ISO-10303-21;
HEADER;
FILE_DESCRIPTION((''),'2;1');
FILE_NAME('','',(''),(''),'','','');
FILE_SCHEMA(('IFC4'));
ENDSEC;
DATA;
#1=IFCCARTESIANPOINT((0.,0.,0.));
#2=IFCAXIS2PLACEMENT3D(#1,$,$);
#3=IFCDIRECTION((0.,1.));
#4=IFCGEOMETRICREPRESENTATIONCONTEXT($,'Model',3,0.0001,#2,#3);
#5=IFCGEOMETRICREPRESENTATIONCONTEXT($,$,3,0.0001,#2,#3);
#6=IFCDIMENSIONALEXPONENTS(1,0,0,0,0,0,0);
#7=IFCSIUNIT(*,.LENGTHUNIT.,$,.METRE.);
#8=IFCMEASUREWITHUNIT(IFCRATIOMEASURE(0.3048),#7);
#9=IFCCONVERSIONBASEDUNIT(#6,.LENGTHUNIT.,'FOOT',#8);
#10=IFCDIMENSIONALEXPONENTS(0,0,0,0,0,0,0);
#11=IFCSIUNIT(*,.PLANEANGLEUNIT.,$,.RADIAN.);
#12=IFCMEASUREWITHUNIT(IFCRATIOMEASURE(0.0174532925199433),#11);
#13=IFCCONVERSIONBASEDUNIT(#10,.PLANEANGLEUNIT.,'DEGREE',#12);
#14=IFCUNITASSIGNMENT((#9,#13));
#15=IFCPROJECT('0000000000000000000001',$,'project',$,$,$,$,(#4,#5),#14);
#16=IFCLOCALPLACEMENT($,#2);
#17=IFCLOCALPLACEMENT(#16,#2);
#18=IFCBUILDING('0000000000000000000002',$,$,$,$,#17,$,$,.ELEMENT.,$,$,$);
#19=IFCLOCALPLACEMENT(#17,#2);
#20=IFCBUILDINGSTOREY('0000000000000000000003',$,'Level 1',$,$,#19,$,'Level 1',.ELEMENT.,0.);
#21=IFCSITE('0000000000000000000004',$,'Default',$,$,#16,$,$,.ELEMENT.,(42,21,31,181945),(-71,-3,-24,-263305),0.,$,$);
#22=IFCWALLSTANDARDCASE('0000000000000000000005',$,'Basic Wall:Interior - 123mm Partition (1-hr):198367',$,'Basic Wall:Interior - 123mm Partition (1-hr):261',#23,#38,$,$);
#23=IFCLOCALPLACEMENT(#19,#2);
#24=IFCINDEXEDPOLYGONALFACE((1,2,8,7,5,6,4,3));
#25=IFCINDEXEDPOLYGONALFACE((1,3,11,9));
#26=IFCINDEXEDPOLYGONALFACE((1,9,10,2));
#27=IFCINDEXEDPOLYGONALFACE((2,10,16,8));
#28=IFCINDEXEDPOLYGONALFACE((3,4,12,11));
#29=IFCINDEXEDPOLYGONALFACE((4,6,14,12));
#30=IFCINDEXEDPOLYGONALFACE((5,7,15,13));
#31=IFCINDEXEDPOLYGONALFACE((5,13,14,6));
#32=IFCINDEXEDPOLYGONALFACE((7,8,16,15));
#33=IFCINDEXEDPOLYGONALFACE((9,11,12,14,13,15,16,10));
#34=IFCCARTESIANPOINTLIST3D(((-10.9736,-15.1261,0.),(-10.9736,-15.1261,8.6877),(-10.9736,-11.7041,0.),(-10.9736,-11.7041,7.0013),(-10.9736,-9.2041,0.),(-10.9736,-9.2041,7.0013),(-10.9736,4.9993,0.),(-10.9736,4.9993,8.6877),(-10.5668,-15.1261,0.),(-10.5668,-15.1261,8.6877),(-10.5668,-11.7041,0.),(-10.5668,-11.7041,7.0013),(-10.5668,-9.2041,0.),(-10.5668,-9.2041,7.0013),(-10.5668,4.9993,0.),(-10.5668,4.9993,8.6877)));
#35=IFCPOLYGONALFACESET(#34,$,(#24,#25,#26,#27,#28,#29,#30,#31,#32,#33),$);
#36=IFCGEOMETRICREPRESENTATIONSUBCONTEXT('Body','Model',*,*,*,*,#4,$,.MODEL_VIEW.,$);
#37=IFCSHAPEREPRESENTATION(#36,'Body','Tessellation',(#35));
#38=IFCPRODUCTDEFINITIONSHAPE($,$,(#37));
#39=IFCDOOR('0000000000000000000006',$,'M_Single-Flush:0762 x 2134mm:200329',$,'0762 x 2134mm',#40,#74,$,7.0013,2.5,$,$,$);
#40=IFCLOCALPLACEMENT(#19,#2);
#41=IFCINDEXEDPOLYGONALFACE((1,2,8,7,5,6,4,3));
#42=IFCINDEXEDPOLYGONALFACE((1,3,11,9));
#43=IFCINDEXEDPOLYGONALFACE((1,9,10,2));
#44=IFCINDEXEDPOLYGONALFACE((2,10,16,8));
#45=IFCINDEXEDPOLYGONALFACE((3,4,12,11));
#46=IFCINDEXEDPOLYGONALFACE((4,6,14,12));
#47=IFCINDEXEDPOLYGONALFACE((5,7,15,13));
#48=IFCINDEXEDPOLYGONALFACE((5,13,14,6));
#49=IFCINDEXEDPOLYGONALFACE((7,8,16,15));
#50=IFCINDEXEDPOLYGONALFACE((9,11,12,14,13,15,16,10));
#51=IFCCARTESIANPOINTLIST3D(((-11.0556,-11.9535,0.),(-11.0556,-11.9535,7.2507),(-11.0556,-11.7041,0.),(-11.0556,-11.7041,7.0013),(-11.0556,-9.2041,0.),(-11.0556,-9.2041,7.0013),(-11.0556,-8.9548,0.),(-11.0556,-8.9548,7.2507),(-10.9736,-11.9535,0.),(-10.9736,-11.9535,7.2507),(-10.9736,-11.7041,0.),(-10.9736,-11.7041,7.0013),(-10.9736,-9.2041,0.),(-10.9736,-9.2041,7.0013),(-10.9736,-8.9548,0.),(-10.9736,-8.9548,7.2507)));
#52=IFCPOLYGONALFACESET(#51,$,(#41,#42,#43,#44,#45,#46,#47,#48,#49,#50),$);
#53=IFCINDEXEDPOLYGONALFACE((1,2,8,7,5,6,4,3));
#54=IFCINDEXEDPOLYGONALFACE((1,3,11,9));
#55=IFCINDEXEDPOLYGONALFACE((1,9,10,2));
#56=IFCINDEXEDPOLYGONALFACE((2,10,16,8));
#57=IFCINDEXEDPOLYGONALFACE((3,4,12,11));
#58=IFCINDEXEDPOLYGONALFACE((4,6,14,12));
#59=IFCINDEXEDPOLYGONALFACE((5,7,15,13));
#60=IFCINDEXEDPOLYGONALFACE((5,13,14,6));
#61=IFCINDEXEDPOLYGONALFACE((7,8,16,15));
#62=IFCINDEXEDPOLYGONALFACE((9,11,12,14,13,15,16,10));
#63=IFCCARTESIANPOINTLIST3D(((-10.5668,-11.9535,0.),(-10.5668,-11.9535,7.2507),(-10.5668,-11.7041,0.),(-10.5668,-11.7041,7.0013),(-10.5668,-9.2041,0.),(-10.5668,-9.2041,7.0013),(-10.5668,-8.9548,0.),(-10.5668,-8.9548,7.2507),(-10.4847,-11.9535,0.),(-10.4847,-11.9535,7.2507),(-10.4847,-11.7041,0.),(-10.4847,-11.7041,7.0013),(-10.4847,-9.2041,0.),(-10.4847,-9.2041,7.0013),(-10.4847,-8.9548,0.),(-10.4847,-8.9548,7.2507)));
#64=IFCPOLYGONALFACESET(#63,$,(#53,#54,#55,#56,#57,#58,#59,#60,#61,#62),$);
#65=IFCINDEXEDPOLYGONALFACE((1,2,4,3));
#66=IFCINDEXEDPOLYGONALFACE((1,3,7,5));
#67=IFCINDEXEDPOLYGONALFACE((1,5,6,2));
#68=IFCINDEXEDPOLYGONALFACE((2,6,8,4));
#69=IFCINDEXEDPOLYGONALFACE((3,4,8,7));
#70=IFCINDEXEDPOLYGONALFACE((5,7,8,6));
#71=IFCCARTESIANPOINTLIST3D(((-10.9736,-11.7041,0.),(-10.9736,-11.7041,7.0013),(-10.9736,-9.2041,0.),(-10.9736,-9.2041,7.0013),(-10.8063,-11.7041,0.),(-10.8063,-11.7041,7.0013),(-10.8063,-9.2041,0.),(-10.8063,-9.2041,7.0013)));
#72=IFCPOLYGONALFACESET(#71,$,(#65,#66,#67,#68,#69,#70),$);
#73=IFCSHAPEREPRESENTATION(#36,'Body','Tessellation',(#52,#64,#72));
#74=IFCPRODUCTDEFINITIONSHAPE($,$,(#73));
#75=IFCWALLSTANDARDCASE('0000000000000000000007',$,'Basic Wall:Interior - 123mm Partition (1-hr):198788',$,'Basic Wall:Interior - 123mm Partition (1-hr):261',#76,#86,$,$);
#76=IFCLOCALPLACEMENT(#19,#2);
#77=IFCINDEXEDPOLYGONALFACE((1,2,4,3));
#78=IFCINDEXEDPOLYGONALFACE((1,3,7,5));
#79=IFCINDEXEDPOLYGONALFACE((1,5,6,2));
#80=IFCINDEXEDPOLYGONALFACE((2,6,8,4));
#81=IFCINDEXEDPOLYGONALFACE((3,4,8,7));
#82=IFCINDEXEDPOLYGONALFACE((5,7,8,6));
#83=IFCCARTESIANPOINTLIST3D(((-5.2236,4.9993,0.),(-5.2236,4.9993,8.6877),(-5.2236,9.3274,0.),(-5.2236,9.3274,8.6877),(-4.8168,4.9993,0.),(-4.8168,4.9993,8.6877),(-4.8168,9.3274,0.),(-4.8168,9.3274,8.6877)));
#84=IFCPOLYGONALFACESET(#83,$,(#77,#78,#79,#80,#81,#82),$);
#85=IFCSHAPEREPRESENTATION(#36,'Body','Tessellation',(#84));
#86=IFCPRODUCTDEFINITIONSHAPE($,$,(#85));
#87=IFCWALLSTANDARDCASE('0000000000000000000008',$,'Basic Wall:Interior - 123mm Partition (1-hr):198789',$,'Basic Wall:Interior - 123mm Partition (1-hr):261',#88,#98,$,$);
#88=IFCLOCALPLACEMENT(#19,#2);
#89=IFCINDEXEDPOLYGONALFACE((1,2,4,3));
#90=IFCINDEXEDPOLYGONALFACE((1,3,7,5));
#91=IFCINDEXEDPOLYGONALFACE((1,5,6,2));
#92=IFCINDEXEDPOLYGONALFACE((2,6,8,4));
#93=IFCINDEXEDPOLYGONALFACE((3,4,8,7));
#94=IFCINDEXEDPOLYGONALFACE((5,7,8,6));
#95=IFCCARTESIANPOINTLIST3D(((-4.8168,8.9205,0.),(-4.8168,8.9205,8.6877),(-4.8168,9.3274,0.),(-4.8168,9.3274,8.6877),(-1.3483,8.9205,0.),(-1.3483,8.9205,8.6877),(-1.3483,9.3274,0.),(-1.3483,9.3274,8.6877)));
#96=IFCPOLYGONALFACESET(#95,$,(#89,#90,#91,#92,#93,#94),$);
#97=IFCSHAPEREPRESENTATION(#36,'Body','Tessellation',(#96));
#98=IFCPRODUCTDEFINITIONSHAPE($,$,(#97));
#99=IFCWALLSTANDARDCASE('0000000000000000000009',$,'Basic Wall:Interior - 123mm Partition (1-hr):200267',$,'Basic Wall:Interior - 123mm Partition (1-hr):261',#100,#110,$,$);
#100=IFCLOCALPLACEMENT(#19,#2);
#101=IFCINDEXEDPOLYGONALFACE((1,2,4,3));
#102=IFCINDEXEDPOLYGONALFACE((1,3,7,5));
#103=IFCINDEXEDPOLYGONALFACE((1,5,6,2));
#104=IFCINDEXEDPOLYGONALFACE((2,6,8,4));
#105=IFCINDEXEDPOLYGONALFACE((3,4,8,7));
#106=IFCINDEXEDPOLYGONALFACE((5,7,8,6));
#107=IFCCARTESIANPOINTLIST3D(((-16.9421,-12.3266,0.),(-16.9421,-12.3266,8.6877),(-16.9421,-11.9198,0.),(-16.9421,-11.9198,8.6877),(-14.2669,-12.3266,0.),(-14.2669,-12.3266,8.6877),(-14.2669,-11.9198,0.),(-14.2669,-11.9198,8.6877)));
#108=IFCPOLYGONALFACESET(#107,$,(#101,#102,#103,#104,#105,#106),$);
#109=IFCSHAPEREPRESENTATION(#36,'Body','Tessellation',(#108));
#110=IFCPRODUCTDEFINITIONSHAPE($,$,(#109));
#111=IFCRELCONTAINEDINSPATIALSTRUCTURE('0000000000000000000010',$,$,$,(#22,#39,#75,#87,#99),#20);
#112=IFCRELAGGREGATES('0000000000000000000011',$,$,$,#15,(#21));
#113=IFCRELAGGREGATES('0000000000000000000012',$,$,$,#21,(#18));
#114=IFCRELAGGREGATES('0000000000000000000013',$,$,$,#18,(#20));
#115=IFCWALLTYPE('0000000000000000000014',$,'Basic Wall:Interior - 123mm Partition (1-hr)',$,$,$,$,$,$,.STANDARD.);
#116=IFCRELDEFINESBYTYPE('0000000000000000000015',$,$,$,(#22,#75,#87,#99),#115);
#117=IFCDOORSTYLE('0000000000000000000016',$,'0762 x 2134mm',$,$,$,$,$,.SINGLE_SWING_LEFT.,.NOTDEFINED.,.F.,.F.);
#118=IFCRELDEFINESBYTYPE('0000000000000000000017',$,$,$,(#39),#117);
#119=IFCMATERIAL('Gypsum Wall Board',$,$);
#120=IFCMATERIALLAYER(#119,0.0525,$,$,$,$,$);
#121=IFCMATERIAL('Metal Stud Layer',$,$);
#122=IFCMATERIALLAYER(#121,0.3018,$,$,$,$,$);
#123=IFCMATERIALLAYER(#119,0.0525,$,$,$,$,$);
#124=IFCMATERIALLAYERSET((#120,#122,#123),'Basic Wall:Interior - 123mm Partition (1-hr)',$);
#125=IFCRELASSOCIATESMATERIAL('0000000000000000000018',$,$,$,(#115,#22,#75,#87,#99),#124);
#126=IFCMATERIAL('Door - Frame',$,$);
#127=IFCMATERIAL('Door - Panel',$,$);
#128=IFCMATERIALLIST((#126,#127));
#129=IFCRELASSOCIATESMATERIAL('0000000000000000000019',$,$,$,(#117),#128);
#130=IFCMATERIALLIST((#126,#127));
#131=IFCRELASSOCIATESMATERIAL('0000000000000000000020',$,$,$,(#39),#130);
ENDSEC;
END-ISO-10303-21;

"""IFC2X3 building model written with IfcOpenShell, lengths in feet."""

from ifc_helpers import new_model, entity, si_unit, converted_unit, direction, frame, frame_2d, origin, origin_2d_with_axis, place, context, subcontext, project, spatial, polyline, rectangle, outline, extrude, clip, bounded_halfspace, source, transform, mapped, material, material_list, layer, layer_set, layer_usage, type_object, type_shapes, element, fill, save


model = new_model("IFC2X3")

# Units and contexts
model_context = context("Model", 3, precision=0.0001, world=origin(), true_north=direction((0.0, 1.0)))
context_of_model = context(None, 3, precision=0.0001, world=origin(), true_north=direction((0.0, 1.0)))
body_context = subcontext(model_context, "Body", "Model", "MODEL_VIEW")
ifc_project = project(units=[converted_unit("LENGTHUNIT", "FOOT", entity("IfcRatioMeasure", 0.3048), si_unit("LENGTHUNIT", "METRE"), dimensions=[1, 0, 0, 0, 0, 0, 0]), converted_unit("PLANEANGLEUNIT", "DEGREE", entity("IfcRatioMeasure", 0.0174532925199433), si_unit("PLANEANGLEUNIT", "RADIAN"), dimensions=[0, 0, 0, 0, 0, 0, 0])], contexts=[model_context, context_of_model])

# Site, building, storey
site_placement = place(None, origin())
site = spatial("IfcSite", under=ifc_project, at=site_placement, Name="Default", CompositionType="ELEMENT", RefLatitude=(42, 21, 31, 181945), RefLongitude=(-71, -3, -24, -263305), RefElevation=0.0)
building_placement = place(site_placement, origin())
building = spatial("IfcBuilding", under=site, at=building_placement, CompositionType="ELEMENT")
storey_placement = place(building_placement, origin())
storey = spatial("IfcBuildingStorey", under=building, at=storey_placement, Name="Level 1", LongName="Level 1", CompositionType="ELEMENT", Elevation=0.0)

# Shared definitions
ifc_material_1 = material(Name="Door - Frame")
ifc_material_2 = material(Name="Door - Panel")

# Wall, openings, door
ifc_material_3 = material(Name="Gypsum Wall Board")
ifc_layer_1 = layer(ifc_material_3, 0.0525)
ifc_material_4 = material(Name="Metal Stud Layer")
ifc_layer_2 = layer(ifc_material_4, 0.3018)
ifc_layer_3 = layer(ifc_material_3, 0.0525)
ifc_layer_set_1 = layer_set([ifc_layer_1, ifc_layer_2, ifc_layer_3], Name="Basic Wall:Interior - 123mm Partition (1-hr)")
ifc_layer_usage_1 = layer_usage(ifc_layer_set_1, "AXIS2", "NEGATIVE", 0.2034)
wall_type_1 = type_object("IfcWallType", Name="Basic Wall:Interior - 123mm Partition (1-hr)", PredefinedType="STANDARD", material=ifc_layer_set_1)
wall_1_placement = place(storey_placement, frame((-10.7702, -15.1261, 0.0), z_axis=(0.0, 0.0, 1.0), x_axis=(0.0, 1.0, 0.0)))
wall_1 = element("IfcWallStandardCase", 1, at=wall_1_placement, inside=storey, type_object=wall_type_1, material=ifc_layer_usage_1, Name="Basic Wall:Interior - 123mm Partition (1-hr):198367", ObjectType="Basic Wall:Interior - 123mm Partition (1-hr):261", context=body_context, shape_type="Clipping", body=[
    clip(extrude(rectangle(XDim=20.1253, YDim=0.4068, at=frame_2d((10.0627, 0.0), x_axis=(-1.0, 0.0))), origin(), (0.0, 0.0, 1.0), 8.6877), bounded_halfspace(frame((0.0, -0.2034, 8.6877), z_axis=(0.0, 0.0, -1.0), x_axis=(0.0, -1.0, 0.0)), True, frame((0.0, -0.2034, 8.6877)), polyline([(0.0, 0.0), (19.7185, 0.0), (20.1253, 0.0), (20.1253, 0.4068), (0.0, 0.4068), (0.0, 0.0)]))),
])
opening_1_placement = place(wall_1_placement, origin())
element("IfcOpeningElement", 2, at=opening_1_placement, cuts=wall_1, ObjectType="Opening", context=body_context, shape_type="SweptSolid", body=[
    extrude(rectangle(XDim=6.6667, YDim=0.4068, at=frame_2d((0.0, 0.0), x_axis=(0.0, 1.0))), frame((15.4219, 0.2034, 3.3333), z_axis=(0.0, 1.0, 0.0), x_axis=(1.0, 0.0, 0.0)), (0.0, 0.0, 1.0), 2.5),
])
opening_2_placement = place(wall_1_placement, frame((3.4219, -0.2034, 0.0)))
opening_2 = element("IfcOpeningElement", 3, at=opening_2_placement, cuts=wall_1, ObjectType="Opening", context=body_context, shape_type="SweptSolid", body=[
    extrude(rectangle(XDim=2.5, YDim=7.0013, at=frame_2d((3.5007, 1.25), x_axis=(0.0, -1.0))), frame((0.0, 0.0, 0.0), z_axis=(0.0, 1.0, 0.0), x_axis=(0.0, 0.0, 1.0)), (0.0, 0.0, 1.0), 0.4068),
])
ifc_material_list_1 = material_list([ifc_material_1, ifc_material_2])
ifc_material_list_2 = material_list([ifc_material_1, ifc_material_2])
door_style_1 = type_object("IfcDoorStyle", Name="0762 x 2134mm", ConstructionType="NOTDEFINED", OperationType="SINGLE_SWING_LEFT", ParameterTakesPrecedence=False, Sizeable=False, material=ifc_material_list_2)
shared_shape_1 = source(origin(), body_context, "Body", "SweptSolid", [
    extrude(outline(polyline([(-1.4993, -3.6877), (1.4993, -3.6877), (1.4993, 3.563), (1.25, 3.563), (1.25, -3.4383), (-1.25, -3.4383), (-1.25, 3.563), (-1.4993, 3.563), (-1.4993, -3.6877)])), frame((1.25, 0.4888, 3.563), z_axis=(0.0, -1.0, 0.0), x_axis=(-1.0, 0.0, 0.0)), (0.0, 0.0, 1.0), 0.082),
    extrude(outline(polyline([(-3.6877, -1.4993), (3.563, -1.4993), (3.563, -1.25), (-3.4383, -1.25), (-3.4383, 1.25), (3.563, 1.25), (3.563, 1.4993), (-3.6877, 1.4993), (-3.6877, -1.4993)])), frame((1.25, 0.0, 3.563), z_axis=(0.0, -1.0, 0.0), x_axis=(0.0, 0.0, -1.0)), (0.0, 0.0, 1.0), 0.082),
    extrude(rectangle(XDim=2.5, YDim=0.1673, at=origin_2d_with_axis()), frame((1.25, 0.3232, 0.0)), (0.0, 0.0, 1.0), 7.0013),
])
type_shapes(door_style_1, [shared_shape_1])
door_1_placement = place(opening_2_placement, origin())
door_1 = element("IfcDoor", 4, at=door_1_placement, inside=storey, type_object=door_style_1, material=ifc_material_list_1, Name="M_Single-Flush:0762 x 2134mm:200329", ObjectType="0762 x 2134mm", OverallHeight=7.0013, OverallWidth=2.5, context=body_context, shape_type="MappedRepresentation", body=[
    mapped(shared_shape_1, transform((0.0, 0.0, 0.0), scale=1.0)),
])
fill(opening_2, door_1)

# Walls
ifc_layer_usage_2 = layer_usage(ifc_layer_set_1, "AXIS2", "NEGATIVE", 0.2034)
wall_2_placement = place(storey_placement, frame((-5.0202, 4.9993, 0.0), z_axis=(0.0, 0.0, 1.0), x_axis=(0.0, 1.0, 0.0)))
element("IfcWallStandardCase", 5, at=wall_2_placement, inside=storey, type_object=wall_type_1, material=ifc_layer_usage_2, Name="Basic Wall:Interior - 123mm Partition (1-hr):198788", ObjectType="Basic Wall:Interior - 123mm Partition (1-hr):261", context=body_context, shape_type="Clipping", body=[
    clip(extrude(rectangle(XDim=4.3281, YDim=0.4068, at=frame_2d((2.164, 0.0), x_axis=(-1.0, 0.0))), origin(), (0.0, 0.0, 1.0), 8.6877), bounded_halfspace(frame((0.0, -0.2034, 8.6877), z_axis=(0.0, 0.0, -1.0), x_axis=(0.0, -1.0, 0.0)), True, frame((0.0, -0.2034, 8.6877)), polyline([(0.0, 0.0), (3.9213, 0.0), (4.3281, 0.0), (4.3281, 0.4068), (0.0, 0.4068), (0.0, 0.0)]))),
])
ifc_layer_usage_3 = layer_usage(ifc_layer_set_1, "AXIS2", "NEGATIVE", 0.2034)
wall_3_placement = place(storey_placement, frame((-4.8168, 9.1239, 0.0)))
element("IfcWallStandardCase", 6, at=wall_3_placement, inside=storey, type_object=wall_type_1, material=ifc_layer_usage_3, Name="Basic Wall:Interior - 123mm Partition (1-hr):198789", ObjectType="Basic Wall:Interior - 123mm Partition (1-hr):261", context=body_context, shape_type="Clipping", body=[
    clip(extrude(rectangle(XDim=3.4685, YDim=0.4068, at=frame_2d((1.7343, 0.0), x_axis=(-1.0, 0.0))), origin(), (0.0, 0.0, 1.0), 8.6877), bounded_halfspace(frame((0.0, -0.2034, 8.6877), z_axis=(0.0, 0.0, -1.0), x_axis=(1.0, 0.0, 0.0)), True, frame((0.0, -0.2034, 8.6877)), polyline([(0.0, 0.0), (3.4685, 0.0), (3.4685, 0.4068), (0.0, 0.4068), (0.0, 0.0)]))),
])
ifc_layer_usage_4 = layer_usage(ifc_layer_set_1, "AXIS2", "NEGATIVE", 0.2034)
wall_4_placement = place(storey_placement, frame((-14.2669, -12.1232, 0.0), z_axis=(0.0, 0.0, 1.0), x_axis=(-1.0, 0.0, 0.0)))
element("IfcWallStandardCase", 7, at=wall_4_placement, inside=storey, type_object=wall_type_1, material=ifc_layer_usage_4, Name="Basic Wall:Interior - 123mm Partition (1-hr):200267", ObjectType="Basic Wall:Interior - 123mm Partition (1-hr):261", context=body_context, shape_type="Clipping", body=[
    clip(extrude(rectangle(XDim=2.6752, YDim=0.4068, at=frame_2d((1.3376, 0.0), x_axis=(-1.0, 0.0))), origin(), (0.0, 0.0, 1.0), 8.6877), bounded_halfspace(frame((0.0, -0.2034, 8.6877), z_axis=(0.0, 0.0, -1.0), x_axis=(-1.0, 0.0, 0.0)), True, frame((0.0, -0.2034, 8.6877)), polyline([(0.0, 0.0), (2.6752, 0.0), (2.6752, 0.4068), (0.0, 0.4068), (0.0, 0.0)]))),
])

save(model, "model.ifc")
